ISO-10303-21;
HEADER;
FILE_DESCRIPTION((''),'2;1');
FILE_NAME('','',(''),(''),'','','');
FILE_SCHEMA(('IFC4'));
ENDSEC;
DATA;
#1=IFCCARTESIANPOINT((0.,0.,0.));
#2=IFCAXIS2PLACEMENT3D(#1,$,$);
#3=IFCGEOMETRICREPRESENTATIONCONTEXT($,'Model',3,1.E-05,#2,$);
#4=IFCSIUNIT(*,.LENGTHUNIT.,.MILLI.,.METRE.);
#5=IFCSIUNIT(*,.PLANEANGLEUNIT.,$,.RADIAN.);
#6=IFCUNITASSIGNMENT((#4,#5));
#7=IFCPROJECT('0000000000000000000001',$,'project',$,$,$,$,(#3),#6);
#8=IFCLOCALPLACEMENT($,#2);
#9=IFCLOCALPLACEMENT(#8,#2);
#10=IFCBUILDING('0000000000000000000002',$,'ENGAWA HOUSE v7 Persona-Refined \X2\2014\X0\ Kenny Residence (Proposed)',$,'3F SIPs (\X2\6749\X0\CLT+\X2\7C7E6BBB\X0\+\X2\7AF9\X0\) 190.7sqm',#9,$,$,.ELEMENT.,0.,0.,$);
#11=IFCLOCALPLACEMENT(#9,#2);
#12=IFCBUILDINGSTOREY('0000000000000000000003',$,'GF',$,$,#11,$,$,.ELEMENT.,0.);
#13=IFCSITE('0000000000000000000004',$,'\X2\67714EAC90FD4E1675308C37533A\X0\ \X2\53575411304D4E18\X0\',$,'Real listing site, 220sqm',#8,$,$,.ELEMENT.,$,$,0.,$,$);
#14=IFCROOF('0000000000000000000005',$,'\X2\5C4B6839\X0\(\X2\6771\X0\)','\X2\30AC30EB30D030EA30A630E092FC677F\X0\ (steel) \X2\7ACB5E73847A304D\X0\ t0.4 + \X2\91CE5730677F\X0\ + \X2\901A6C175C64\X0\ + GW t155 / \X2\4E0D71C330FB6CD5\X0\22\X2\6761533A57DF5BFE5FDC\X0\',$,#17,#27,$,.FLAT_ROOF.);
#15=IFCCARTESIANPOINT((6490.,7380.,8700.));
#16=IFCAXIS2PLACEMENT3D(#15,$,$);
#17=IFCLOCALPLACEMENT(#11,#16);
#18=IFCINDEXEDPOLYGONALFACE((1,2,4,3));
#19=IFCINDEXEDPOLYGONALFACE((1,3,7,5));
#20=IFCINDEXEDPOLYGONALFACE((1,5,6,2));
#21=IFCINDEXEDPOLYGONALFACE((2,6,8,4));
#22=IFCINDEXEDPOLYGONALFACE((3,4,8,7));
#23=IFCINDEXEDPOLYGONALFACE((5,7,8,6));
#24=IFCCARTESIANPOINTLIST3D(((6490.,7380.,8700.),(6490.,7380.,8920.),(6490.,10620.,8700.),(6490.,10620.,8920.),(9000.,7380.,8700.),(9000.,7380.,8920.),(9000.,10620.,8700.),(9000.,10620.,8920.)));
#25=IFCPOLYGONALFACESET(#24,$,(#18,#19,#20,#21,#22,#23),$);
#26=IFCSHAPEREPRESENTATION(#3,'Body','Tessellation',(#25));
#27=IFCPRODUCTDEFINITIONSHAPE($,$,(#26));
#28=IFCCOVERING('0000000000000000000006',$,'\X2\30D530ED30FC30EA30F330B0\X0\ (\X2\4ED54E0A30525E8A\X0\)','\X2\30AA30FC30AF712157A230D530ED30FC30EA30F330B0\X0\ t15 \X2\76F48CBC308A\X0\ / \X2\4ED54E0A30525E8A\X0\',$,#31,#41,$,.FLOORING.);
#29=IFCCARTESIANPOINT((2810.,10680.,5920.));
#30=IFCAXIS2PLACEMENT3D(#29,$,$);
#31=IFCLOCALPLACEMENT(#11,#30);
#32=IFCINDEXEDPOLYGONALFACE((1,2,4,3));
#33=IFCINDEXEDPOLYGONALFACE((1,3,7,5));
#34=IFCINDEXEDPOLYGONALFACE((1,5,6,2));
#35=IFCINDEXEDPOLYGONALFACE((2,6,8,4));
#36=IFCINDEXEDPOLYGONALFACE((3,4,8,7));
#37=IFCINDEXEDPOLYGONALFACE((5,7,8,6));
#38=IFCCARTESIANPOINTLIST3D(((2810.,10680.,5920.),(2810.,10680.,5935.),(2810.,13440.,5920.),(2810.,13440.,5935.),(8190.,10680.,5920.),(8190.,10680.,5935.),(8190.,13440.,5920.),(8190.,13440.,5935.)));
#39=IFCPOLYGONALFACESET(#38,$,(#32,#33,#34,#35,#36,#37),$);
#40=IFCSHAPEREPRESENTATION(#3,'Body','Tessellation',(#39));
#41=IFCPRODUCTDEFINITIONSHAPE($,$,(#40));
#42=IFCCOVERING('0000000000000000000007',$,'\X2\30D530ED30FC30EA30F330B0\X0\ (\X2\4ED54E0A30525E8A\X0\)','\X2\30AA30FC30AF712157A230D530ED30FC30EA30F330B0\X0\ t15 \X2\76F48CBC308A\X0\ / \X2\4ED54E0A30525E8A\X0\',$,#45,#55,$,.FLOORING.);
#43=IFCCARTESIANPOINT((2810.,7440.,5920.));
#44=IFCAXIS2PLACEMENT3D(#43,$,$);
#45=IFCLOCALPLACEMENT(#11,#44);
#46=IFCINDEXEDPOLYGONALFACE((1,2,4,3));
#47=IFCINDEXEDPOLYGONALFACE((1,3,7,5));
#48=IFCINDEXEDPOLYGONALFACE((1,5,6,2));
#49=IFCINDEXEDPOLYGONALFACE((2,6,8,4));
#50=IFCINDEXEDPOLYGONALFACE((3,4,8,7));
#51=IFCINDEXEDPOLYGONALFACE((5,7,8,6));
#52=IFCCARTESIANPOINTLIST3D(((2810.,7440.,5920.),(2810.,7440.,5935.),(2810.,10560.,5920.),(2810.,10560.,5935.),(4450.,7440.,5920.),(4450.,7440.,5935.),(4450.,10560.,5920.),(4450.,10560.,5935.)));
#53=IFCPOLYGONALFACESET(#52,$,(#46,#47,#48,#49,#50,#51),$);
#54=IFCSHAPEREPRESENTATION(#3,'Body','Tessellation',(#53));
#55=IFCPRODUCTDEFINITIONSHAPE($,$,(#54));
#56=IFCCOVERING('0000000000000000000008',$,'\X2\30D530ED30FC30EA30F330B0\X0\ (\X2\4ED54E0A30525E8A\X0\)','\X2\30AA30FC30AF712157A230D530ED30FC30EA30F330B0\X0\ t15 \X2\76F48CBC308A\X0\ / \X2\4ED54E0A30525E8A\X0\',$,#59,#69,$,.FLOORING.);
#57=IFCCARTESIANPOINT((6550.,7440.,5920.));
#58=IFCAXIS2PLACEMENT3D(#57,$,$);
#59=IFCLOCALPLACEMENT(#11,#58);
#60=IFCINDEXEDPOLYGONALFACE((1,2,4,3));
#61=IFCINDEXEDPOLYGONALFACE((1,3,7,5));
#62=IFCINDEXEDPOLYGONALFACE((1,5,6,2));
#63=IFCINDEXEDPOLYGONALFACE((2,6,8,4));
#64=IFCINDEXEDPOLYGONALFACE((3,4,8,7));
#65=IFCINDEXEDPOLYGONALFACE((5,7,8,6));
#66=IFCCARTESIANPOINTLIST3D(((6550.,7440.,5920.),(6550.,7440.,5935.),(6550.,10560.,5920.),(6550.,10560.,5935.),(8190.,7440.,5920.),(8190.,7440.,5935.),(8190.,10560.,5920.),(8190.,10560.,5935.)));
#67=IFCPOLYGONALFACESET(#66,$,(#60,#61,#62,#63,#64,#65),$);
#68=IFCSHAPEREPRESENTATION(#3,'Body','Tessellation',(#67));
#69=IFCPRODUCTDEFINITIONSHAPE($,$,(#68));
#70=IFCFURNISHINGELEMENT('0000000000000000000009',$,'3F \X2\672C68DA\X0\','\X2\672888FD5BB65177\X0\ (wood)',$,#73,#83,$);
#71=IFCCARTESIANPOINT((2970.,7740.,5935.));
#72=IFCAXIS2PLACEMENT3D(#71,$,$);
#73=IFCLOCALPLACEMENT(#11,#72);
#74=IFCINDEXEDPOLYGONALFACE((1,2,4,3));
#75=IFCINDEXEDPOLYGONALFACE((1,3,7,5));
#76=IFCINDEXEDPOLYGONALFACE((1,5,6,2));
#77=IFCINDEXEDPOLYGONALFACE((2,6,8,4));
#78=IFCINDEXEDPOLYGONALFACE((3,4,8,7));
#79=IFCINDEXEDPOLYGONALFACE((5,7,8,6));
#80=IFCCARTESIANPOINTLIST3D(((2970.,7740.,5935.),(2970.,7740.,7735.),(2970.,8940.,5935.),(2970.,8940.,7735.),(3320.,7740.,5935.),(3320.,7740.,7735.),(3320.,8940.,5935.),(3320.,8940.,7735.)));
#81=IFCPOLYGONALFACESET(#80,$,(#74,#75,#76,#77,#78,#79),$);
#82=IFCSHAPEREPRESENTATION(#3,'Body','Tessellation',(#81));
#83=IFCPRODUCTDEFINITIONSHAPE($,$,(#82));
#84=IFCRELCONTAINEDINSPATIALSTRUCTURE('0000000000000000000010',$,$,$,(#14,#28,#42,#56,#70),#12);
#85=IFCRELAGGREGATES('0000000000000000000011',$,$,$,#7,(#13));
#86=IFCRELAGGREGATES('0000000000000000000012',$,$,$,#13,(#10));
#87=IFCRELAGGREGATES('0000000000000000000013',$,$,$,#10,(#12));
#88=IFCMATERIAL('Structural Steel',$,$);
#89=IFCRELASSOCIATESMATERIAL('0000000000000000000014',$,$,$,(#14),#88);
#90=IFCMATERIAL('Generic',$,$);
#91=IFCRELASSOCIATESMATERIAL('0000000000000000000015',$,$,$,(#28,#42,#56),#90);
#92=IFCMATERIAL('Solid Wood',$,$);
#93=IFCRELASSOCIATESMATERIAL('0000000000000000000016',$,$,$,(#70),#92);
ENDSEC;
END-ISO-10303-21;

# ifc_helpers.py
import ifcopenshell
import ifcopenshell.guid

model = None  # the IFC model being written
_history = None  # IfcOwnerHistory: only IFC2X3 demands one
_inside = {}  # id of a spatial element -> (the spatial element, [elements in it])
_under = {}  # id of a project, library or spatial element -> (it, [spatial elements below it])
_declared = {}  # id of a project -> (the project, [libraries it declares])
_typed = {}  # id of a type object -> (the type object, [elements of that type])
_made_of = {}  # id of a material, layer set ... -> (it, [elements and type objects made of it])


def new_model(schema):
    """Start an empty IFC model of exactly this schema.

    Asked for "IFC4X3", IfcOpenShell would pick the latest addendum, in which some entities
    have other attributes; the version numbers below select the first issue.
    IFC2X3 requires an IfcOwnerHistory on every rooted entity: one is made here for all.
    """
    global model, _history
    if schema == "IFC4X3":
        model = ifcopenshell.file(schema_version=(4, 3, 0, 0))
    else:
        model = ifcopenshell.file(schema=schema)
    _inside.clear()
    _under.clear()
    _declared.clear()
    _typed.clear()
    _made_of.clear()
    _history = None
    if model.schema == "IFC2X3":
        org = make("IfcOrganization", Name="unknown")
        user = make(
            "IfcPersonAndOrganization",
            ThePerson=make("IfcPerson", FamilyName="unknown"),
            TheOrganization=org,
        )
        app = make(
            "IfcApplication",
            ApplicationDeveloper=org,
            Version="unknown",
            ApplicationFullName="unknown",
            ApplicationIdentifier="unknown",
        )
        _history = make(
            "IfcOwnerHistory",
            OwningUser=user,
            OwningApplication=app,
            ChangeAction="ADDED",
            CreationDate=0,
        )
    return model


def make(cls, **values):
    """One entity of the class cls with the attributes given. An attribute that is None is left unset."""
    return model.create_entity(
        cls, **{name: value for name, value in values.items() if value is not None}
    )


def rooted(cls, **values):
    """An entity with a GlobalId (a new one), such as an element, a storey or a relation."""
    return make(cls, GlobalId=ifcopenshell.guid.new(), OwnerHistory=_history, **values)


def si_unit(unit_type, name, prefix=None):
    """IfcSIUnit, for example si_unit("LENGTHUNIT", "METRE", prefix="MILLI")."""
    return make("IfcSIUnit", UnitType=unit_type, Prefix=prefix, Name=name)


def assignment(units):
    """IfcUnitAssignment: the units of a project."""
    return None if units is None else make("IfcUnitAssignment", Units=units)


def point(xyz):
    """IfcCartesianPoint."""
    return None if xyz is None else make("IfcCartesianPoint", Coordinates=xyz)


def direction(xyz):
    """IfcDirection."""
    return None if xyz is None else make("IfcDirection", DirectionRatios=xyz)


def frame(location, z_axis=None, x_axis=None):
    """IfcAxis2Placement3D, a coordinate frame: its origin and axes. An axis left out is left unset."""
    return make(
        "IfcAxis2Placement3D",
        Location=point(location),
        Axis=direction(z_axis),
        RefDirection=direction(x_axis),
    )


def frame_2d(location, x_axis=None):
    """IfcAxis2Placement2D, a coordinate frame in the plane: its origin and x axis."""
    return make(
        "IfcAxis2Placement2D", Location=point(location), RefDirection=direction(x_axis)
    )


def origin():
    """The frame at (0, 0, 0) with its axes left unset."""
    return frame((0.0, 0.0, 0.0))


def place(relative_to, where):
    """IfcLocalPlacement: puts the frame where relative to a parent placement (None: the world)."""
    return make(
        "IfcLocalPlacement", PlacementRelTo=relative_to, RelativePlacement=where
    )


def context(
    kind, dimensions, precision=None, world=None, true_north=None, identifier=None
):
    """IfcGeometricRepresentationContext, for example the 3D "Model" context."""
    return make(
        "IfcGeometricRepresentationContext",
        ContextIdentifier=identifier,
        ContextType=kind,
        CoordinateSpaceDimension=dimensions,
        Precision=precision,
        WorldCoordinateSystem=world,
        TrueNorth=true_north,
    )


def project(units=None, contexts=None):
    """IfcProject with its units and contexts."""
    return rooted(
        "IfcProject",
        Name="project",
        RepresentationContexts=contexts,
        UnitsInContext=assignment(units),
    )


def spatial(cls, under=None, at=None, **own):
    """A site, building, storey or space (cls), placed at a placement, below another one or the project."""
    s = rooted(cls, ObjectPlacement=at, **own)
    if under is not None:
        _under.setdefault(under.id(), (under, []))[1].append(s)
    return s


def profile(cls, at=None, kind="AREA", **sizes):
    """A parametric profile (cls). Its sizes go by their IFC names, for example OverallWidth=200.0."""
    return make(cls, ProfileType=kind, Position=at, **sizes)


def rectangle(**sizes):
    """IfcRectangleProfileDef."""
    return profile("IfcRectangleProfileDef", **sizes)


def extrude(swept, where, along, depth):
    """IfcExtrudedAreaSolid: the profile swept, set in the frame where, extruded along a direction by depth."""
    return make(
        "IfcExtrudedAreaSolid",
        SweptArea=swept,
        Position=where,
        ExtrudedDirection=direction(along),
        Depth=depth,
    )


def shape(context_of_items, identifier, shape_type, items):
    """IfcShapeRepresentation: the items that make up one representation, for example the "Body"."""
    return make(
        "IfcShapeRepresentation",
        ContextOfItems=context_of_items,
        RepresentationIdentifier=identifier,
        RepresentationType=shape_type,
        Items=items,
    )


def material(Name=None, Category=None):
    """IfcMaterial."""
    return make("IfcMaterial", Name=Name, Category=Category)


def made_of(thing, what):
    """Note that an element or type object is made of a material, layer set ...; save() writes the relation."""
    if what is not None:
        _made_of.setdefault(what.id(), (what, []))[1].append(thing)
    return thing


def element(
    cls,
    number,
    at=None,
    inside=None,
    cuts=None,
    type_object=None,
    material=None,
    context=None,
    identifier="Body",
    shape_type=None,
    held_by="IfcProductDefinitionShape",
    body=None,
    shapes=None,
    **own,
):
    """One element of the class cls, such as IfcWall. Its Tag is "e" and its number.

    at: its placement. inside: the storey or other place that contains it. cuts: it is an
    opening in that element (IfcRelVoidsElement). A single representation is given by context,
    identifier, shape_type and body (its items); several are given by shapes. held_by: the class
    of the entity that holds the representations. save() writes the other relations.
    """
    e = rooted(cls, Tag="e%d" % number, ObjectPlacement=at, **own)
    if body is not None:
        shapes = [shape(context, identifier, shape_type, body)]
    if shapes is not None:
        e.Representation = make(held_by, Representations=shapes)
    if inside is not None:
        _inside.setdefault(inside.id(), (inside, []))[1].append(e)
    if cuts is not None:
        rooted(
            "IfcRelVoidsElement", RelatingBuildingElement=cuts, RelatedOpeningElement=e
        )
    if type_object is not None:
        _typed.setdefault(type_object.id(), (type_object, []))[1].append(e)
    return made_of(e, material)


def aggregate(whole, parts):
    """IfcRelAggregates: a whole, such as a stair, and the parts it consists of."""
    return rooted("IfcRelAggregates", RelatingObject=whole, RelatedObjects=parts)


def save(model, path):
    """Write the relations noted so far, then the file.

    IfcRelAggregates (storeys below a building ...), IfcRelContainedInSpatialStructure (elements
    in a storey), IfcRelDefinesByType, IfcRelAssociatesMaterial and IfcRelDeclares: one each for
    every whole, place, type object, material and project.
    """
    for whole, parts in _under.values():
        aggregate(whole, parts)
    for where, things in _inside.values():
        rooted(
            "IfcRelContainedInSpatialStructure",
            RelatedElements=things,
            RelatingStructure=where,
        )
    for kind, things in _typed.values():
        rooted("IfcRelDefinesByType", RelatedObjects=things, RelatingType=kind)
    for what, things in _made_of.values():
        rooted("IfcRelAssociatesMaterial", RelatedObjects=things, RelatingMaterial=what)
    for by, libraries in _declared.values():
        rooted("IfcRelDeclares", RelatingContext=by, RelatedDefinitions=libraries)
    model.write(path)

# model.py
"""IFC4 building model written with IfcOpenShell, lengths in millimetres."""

from ifc_helpers import new_model, si_unit, frame, frame_2d, origin, place, context, project, spatial, rectangle, extrude, material, element, save


model = new_model("IFC4")

# Units and contexts
model_context = context("Model", 3, precision=1e-05, world=origin())
ifc_project = project(units=[si_unit("LENGTHUNIT", "METRE", prefix="MILLI"), si_unit("PLANEANGLEUNIT", "RADIAN")], contexts=[model_context])

# Site, building, storey
site_placement = place(None, origin())
site = spatial("IfcSite", under=ifc_project, at=site_placement, Name="東京都世田谷区 南向き丘", ObjectType="Real listing site, 220sqm", CompositionType="ELEMENT", RefElevation=0.0)
building_placement = place(site_placement, origin())
building = spatial("IfcBuilding", under=site, at=building_placement, Name="ENGAWA HOUSE v7 Persona-Refined — Kenny Residence (Proposed)", ObjectType="3F SIPs (杉CLT+籾殻+竹) 190.7sqm", CompositionType="ELEMENT", ElevationOfRefHeight=0.0, ElevationOfTerrain=0.0)
storey_placement = place(building_placement, origin())
storey = spatial("IfcBuildingStorey", under=building, at=storey_placement, Name="GF", CompositionType="ELEMENT", Elevation=0.0)

# Shared definitions
ifc_material_1 = material(Name="Solid Wood")

# Shared definitions
ifc_material_2 = material(Name="Generic")

# Roof
ifc_material_3 = material(Name="Structural Steel")
roof_1_placement = place(storey_placement, frame((6490.0, 7380.0, 8700.0)))
element("IfcRoof", 1, at=roof_1_placement, inside=storey, material=ifc_material_3, Name="屋根(東)", Description="ガルバリウム鋼板 (steel) 立平葺き t0.4 + 野地板 + 通気層 + GW t155 / 不燃・法22条区域対応", PredefinedType="FLAT_ROOF", context=model_context, shape_type="SweptSolid", body=[
    extrude(rectangle(XDim=2510.0, YDim=3240.0, at=frame_2d((1255.0, 1620.0))), frame((6490.0, 7380.0, 8700.0)), (0.0, 0.0, 1.0), 220.0),
])

# Coverings
covering_1_placement = place(storey_placement, frame((2810.0, 10680.0, 5920.0)))
element("IfcCovering", 2, at=covering_1_placement, inside=storey, material=ifc_material_2, Name="フローリング (仕上げ床)", Description="オーク無垢フローリング t15 直貼り / 仕上げ床", PredefinedType="FLOORING", context=model_context, shape_type="SweptSolid", body=[
    extrude(rectangle(XDim=5380.0, YDim=2760.0, at=frame_2d((2690.0, 1380.0))), frame((2810.0, 10680.0, 5920.0)), (0.0, 0.0, 1.0), 15.0),
])
covering_2_placement = place(storey_placement, frame((2810.0, 7440.0, 5920.0)))
element("IfcCovering", 3, at=covering_2_placement, inside=storey, material=ifc_material_2, Name="フローリング (仕上げ床)", Description="オーク無垢フローリング t15 直貼り / 仕上げ床", PredefinedType="FLOORING", context=model_context, shape_type="SweptSolid", body=[
    extrude(rectangle(XDim=1640.0, YDim=3120.0, at=frame_2d((820.0, 1560.0))), frame((2810.0, 7440.0, 5920.0)), (0.0, 0.0, 1.0), 15.0),
])
covering_3_placement = place(storey_placement, frame((6550.0, 7440.0, 5920.0)))
element("IfcCovering", 4, at=covering_3_placement, inside=storey, material=ifc_material_2, Name="フローリング (仕上げ床)", Description="オーク無垢フローリング t15 直貼り / 仕上げ床", PredefinedType="FLOORING", context=model_context, shape_type="SweptSolid", body=[
    extrude(rectangle(XDim=1640.0, YDim=3120.0, at=frame_2d((820.0, 1560.0))), frame((6550.0, 7440.0, 5920.0)), (0.0, 0.0, 1.0), 15.0),
])

# Furnishing element
furnishing_placement = place(storey_placement, frame((2970.0, 7740.0, 5935.0)))
element("IfcFurnishingElement", 5, at=furnishing_placement, inside=storey, material=ifc_material_1, Name="3F 本棚", Description="木製家具 (wood)", context=model_context, shape_type="SweptSolid", body=[
    extrude(rectangle(XDim=350.0, YDim=1200.0, at=frame_2d((175.0, 600.0))), frame((2970.0, 7740.0, 5935.0)), (0.0, 0.0, 1.0), 1800.0),
])

save(model, "model.ifc")
